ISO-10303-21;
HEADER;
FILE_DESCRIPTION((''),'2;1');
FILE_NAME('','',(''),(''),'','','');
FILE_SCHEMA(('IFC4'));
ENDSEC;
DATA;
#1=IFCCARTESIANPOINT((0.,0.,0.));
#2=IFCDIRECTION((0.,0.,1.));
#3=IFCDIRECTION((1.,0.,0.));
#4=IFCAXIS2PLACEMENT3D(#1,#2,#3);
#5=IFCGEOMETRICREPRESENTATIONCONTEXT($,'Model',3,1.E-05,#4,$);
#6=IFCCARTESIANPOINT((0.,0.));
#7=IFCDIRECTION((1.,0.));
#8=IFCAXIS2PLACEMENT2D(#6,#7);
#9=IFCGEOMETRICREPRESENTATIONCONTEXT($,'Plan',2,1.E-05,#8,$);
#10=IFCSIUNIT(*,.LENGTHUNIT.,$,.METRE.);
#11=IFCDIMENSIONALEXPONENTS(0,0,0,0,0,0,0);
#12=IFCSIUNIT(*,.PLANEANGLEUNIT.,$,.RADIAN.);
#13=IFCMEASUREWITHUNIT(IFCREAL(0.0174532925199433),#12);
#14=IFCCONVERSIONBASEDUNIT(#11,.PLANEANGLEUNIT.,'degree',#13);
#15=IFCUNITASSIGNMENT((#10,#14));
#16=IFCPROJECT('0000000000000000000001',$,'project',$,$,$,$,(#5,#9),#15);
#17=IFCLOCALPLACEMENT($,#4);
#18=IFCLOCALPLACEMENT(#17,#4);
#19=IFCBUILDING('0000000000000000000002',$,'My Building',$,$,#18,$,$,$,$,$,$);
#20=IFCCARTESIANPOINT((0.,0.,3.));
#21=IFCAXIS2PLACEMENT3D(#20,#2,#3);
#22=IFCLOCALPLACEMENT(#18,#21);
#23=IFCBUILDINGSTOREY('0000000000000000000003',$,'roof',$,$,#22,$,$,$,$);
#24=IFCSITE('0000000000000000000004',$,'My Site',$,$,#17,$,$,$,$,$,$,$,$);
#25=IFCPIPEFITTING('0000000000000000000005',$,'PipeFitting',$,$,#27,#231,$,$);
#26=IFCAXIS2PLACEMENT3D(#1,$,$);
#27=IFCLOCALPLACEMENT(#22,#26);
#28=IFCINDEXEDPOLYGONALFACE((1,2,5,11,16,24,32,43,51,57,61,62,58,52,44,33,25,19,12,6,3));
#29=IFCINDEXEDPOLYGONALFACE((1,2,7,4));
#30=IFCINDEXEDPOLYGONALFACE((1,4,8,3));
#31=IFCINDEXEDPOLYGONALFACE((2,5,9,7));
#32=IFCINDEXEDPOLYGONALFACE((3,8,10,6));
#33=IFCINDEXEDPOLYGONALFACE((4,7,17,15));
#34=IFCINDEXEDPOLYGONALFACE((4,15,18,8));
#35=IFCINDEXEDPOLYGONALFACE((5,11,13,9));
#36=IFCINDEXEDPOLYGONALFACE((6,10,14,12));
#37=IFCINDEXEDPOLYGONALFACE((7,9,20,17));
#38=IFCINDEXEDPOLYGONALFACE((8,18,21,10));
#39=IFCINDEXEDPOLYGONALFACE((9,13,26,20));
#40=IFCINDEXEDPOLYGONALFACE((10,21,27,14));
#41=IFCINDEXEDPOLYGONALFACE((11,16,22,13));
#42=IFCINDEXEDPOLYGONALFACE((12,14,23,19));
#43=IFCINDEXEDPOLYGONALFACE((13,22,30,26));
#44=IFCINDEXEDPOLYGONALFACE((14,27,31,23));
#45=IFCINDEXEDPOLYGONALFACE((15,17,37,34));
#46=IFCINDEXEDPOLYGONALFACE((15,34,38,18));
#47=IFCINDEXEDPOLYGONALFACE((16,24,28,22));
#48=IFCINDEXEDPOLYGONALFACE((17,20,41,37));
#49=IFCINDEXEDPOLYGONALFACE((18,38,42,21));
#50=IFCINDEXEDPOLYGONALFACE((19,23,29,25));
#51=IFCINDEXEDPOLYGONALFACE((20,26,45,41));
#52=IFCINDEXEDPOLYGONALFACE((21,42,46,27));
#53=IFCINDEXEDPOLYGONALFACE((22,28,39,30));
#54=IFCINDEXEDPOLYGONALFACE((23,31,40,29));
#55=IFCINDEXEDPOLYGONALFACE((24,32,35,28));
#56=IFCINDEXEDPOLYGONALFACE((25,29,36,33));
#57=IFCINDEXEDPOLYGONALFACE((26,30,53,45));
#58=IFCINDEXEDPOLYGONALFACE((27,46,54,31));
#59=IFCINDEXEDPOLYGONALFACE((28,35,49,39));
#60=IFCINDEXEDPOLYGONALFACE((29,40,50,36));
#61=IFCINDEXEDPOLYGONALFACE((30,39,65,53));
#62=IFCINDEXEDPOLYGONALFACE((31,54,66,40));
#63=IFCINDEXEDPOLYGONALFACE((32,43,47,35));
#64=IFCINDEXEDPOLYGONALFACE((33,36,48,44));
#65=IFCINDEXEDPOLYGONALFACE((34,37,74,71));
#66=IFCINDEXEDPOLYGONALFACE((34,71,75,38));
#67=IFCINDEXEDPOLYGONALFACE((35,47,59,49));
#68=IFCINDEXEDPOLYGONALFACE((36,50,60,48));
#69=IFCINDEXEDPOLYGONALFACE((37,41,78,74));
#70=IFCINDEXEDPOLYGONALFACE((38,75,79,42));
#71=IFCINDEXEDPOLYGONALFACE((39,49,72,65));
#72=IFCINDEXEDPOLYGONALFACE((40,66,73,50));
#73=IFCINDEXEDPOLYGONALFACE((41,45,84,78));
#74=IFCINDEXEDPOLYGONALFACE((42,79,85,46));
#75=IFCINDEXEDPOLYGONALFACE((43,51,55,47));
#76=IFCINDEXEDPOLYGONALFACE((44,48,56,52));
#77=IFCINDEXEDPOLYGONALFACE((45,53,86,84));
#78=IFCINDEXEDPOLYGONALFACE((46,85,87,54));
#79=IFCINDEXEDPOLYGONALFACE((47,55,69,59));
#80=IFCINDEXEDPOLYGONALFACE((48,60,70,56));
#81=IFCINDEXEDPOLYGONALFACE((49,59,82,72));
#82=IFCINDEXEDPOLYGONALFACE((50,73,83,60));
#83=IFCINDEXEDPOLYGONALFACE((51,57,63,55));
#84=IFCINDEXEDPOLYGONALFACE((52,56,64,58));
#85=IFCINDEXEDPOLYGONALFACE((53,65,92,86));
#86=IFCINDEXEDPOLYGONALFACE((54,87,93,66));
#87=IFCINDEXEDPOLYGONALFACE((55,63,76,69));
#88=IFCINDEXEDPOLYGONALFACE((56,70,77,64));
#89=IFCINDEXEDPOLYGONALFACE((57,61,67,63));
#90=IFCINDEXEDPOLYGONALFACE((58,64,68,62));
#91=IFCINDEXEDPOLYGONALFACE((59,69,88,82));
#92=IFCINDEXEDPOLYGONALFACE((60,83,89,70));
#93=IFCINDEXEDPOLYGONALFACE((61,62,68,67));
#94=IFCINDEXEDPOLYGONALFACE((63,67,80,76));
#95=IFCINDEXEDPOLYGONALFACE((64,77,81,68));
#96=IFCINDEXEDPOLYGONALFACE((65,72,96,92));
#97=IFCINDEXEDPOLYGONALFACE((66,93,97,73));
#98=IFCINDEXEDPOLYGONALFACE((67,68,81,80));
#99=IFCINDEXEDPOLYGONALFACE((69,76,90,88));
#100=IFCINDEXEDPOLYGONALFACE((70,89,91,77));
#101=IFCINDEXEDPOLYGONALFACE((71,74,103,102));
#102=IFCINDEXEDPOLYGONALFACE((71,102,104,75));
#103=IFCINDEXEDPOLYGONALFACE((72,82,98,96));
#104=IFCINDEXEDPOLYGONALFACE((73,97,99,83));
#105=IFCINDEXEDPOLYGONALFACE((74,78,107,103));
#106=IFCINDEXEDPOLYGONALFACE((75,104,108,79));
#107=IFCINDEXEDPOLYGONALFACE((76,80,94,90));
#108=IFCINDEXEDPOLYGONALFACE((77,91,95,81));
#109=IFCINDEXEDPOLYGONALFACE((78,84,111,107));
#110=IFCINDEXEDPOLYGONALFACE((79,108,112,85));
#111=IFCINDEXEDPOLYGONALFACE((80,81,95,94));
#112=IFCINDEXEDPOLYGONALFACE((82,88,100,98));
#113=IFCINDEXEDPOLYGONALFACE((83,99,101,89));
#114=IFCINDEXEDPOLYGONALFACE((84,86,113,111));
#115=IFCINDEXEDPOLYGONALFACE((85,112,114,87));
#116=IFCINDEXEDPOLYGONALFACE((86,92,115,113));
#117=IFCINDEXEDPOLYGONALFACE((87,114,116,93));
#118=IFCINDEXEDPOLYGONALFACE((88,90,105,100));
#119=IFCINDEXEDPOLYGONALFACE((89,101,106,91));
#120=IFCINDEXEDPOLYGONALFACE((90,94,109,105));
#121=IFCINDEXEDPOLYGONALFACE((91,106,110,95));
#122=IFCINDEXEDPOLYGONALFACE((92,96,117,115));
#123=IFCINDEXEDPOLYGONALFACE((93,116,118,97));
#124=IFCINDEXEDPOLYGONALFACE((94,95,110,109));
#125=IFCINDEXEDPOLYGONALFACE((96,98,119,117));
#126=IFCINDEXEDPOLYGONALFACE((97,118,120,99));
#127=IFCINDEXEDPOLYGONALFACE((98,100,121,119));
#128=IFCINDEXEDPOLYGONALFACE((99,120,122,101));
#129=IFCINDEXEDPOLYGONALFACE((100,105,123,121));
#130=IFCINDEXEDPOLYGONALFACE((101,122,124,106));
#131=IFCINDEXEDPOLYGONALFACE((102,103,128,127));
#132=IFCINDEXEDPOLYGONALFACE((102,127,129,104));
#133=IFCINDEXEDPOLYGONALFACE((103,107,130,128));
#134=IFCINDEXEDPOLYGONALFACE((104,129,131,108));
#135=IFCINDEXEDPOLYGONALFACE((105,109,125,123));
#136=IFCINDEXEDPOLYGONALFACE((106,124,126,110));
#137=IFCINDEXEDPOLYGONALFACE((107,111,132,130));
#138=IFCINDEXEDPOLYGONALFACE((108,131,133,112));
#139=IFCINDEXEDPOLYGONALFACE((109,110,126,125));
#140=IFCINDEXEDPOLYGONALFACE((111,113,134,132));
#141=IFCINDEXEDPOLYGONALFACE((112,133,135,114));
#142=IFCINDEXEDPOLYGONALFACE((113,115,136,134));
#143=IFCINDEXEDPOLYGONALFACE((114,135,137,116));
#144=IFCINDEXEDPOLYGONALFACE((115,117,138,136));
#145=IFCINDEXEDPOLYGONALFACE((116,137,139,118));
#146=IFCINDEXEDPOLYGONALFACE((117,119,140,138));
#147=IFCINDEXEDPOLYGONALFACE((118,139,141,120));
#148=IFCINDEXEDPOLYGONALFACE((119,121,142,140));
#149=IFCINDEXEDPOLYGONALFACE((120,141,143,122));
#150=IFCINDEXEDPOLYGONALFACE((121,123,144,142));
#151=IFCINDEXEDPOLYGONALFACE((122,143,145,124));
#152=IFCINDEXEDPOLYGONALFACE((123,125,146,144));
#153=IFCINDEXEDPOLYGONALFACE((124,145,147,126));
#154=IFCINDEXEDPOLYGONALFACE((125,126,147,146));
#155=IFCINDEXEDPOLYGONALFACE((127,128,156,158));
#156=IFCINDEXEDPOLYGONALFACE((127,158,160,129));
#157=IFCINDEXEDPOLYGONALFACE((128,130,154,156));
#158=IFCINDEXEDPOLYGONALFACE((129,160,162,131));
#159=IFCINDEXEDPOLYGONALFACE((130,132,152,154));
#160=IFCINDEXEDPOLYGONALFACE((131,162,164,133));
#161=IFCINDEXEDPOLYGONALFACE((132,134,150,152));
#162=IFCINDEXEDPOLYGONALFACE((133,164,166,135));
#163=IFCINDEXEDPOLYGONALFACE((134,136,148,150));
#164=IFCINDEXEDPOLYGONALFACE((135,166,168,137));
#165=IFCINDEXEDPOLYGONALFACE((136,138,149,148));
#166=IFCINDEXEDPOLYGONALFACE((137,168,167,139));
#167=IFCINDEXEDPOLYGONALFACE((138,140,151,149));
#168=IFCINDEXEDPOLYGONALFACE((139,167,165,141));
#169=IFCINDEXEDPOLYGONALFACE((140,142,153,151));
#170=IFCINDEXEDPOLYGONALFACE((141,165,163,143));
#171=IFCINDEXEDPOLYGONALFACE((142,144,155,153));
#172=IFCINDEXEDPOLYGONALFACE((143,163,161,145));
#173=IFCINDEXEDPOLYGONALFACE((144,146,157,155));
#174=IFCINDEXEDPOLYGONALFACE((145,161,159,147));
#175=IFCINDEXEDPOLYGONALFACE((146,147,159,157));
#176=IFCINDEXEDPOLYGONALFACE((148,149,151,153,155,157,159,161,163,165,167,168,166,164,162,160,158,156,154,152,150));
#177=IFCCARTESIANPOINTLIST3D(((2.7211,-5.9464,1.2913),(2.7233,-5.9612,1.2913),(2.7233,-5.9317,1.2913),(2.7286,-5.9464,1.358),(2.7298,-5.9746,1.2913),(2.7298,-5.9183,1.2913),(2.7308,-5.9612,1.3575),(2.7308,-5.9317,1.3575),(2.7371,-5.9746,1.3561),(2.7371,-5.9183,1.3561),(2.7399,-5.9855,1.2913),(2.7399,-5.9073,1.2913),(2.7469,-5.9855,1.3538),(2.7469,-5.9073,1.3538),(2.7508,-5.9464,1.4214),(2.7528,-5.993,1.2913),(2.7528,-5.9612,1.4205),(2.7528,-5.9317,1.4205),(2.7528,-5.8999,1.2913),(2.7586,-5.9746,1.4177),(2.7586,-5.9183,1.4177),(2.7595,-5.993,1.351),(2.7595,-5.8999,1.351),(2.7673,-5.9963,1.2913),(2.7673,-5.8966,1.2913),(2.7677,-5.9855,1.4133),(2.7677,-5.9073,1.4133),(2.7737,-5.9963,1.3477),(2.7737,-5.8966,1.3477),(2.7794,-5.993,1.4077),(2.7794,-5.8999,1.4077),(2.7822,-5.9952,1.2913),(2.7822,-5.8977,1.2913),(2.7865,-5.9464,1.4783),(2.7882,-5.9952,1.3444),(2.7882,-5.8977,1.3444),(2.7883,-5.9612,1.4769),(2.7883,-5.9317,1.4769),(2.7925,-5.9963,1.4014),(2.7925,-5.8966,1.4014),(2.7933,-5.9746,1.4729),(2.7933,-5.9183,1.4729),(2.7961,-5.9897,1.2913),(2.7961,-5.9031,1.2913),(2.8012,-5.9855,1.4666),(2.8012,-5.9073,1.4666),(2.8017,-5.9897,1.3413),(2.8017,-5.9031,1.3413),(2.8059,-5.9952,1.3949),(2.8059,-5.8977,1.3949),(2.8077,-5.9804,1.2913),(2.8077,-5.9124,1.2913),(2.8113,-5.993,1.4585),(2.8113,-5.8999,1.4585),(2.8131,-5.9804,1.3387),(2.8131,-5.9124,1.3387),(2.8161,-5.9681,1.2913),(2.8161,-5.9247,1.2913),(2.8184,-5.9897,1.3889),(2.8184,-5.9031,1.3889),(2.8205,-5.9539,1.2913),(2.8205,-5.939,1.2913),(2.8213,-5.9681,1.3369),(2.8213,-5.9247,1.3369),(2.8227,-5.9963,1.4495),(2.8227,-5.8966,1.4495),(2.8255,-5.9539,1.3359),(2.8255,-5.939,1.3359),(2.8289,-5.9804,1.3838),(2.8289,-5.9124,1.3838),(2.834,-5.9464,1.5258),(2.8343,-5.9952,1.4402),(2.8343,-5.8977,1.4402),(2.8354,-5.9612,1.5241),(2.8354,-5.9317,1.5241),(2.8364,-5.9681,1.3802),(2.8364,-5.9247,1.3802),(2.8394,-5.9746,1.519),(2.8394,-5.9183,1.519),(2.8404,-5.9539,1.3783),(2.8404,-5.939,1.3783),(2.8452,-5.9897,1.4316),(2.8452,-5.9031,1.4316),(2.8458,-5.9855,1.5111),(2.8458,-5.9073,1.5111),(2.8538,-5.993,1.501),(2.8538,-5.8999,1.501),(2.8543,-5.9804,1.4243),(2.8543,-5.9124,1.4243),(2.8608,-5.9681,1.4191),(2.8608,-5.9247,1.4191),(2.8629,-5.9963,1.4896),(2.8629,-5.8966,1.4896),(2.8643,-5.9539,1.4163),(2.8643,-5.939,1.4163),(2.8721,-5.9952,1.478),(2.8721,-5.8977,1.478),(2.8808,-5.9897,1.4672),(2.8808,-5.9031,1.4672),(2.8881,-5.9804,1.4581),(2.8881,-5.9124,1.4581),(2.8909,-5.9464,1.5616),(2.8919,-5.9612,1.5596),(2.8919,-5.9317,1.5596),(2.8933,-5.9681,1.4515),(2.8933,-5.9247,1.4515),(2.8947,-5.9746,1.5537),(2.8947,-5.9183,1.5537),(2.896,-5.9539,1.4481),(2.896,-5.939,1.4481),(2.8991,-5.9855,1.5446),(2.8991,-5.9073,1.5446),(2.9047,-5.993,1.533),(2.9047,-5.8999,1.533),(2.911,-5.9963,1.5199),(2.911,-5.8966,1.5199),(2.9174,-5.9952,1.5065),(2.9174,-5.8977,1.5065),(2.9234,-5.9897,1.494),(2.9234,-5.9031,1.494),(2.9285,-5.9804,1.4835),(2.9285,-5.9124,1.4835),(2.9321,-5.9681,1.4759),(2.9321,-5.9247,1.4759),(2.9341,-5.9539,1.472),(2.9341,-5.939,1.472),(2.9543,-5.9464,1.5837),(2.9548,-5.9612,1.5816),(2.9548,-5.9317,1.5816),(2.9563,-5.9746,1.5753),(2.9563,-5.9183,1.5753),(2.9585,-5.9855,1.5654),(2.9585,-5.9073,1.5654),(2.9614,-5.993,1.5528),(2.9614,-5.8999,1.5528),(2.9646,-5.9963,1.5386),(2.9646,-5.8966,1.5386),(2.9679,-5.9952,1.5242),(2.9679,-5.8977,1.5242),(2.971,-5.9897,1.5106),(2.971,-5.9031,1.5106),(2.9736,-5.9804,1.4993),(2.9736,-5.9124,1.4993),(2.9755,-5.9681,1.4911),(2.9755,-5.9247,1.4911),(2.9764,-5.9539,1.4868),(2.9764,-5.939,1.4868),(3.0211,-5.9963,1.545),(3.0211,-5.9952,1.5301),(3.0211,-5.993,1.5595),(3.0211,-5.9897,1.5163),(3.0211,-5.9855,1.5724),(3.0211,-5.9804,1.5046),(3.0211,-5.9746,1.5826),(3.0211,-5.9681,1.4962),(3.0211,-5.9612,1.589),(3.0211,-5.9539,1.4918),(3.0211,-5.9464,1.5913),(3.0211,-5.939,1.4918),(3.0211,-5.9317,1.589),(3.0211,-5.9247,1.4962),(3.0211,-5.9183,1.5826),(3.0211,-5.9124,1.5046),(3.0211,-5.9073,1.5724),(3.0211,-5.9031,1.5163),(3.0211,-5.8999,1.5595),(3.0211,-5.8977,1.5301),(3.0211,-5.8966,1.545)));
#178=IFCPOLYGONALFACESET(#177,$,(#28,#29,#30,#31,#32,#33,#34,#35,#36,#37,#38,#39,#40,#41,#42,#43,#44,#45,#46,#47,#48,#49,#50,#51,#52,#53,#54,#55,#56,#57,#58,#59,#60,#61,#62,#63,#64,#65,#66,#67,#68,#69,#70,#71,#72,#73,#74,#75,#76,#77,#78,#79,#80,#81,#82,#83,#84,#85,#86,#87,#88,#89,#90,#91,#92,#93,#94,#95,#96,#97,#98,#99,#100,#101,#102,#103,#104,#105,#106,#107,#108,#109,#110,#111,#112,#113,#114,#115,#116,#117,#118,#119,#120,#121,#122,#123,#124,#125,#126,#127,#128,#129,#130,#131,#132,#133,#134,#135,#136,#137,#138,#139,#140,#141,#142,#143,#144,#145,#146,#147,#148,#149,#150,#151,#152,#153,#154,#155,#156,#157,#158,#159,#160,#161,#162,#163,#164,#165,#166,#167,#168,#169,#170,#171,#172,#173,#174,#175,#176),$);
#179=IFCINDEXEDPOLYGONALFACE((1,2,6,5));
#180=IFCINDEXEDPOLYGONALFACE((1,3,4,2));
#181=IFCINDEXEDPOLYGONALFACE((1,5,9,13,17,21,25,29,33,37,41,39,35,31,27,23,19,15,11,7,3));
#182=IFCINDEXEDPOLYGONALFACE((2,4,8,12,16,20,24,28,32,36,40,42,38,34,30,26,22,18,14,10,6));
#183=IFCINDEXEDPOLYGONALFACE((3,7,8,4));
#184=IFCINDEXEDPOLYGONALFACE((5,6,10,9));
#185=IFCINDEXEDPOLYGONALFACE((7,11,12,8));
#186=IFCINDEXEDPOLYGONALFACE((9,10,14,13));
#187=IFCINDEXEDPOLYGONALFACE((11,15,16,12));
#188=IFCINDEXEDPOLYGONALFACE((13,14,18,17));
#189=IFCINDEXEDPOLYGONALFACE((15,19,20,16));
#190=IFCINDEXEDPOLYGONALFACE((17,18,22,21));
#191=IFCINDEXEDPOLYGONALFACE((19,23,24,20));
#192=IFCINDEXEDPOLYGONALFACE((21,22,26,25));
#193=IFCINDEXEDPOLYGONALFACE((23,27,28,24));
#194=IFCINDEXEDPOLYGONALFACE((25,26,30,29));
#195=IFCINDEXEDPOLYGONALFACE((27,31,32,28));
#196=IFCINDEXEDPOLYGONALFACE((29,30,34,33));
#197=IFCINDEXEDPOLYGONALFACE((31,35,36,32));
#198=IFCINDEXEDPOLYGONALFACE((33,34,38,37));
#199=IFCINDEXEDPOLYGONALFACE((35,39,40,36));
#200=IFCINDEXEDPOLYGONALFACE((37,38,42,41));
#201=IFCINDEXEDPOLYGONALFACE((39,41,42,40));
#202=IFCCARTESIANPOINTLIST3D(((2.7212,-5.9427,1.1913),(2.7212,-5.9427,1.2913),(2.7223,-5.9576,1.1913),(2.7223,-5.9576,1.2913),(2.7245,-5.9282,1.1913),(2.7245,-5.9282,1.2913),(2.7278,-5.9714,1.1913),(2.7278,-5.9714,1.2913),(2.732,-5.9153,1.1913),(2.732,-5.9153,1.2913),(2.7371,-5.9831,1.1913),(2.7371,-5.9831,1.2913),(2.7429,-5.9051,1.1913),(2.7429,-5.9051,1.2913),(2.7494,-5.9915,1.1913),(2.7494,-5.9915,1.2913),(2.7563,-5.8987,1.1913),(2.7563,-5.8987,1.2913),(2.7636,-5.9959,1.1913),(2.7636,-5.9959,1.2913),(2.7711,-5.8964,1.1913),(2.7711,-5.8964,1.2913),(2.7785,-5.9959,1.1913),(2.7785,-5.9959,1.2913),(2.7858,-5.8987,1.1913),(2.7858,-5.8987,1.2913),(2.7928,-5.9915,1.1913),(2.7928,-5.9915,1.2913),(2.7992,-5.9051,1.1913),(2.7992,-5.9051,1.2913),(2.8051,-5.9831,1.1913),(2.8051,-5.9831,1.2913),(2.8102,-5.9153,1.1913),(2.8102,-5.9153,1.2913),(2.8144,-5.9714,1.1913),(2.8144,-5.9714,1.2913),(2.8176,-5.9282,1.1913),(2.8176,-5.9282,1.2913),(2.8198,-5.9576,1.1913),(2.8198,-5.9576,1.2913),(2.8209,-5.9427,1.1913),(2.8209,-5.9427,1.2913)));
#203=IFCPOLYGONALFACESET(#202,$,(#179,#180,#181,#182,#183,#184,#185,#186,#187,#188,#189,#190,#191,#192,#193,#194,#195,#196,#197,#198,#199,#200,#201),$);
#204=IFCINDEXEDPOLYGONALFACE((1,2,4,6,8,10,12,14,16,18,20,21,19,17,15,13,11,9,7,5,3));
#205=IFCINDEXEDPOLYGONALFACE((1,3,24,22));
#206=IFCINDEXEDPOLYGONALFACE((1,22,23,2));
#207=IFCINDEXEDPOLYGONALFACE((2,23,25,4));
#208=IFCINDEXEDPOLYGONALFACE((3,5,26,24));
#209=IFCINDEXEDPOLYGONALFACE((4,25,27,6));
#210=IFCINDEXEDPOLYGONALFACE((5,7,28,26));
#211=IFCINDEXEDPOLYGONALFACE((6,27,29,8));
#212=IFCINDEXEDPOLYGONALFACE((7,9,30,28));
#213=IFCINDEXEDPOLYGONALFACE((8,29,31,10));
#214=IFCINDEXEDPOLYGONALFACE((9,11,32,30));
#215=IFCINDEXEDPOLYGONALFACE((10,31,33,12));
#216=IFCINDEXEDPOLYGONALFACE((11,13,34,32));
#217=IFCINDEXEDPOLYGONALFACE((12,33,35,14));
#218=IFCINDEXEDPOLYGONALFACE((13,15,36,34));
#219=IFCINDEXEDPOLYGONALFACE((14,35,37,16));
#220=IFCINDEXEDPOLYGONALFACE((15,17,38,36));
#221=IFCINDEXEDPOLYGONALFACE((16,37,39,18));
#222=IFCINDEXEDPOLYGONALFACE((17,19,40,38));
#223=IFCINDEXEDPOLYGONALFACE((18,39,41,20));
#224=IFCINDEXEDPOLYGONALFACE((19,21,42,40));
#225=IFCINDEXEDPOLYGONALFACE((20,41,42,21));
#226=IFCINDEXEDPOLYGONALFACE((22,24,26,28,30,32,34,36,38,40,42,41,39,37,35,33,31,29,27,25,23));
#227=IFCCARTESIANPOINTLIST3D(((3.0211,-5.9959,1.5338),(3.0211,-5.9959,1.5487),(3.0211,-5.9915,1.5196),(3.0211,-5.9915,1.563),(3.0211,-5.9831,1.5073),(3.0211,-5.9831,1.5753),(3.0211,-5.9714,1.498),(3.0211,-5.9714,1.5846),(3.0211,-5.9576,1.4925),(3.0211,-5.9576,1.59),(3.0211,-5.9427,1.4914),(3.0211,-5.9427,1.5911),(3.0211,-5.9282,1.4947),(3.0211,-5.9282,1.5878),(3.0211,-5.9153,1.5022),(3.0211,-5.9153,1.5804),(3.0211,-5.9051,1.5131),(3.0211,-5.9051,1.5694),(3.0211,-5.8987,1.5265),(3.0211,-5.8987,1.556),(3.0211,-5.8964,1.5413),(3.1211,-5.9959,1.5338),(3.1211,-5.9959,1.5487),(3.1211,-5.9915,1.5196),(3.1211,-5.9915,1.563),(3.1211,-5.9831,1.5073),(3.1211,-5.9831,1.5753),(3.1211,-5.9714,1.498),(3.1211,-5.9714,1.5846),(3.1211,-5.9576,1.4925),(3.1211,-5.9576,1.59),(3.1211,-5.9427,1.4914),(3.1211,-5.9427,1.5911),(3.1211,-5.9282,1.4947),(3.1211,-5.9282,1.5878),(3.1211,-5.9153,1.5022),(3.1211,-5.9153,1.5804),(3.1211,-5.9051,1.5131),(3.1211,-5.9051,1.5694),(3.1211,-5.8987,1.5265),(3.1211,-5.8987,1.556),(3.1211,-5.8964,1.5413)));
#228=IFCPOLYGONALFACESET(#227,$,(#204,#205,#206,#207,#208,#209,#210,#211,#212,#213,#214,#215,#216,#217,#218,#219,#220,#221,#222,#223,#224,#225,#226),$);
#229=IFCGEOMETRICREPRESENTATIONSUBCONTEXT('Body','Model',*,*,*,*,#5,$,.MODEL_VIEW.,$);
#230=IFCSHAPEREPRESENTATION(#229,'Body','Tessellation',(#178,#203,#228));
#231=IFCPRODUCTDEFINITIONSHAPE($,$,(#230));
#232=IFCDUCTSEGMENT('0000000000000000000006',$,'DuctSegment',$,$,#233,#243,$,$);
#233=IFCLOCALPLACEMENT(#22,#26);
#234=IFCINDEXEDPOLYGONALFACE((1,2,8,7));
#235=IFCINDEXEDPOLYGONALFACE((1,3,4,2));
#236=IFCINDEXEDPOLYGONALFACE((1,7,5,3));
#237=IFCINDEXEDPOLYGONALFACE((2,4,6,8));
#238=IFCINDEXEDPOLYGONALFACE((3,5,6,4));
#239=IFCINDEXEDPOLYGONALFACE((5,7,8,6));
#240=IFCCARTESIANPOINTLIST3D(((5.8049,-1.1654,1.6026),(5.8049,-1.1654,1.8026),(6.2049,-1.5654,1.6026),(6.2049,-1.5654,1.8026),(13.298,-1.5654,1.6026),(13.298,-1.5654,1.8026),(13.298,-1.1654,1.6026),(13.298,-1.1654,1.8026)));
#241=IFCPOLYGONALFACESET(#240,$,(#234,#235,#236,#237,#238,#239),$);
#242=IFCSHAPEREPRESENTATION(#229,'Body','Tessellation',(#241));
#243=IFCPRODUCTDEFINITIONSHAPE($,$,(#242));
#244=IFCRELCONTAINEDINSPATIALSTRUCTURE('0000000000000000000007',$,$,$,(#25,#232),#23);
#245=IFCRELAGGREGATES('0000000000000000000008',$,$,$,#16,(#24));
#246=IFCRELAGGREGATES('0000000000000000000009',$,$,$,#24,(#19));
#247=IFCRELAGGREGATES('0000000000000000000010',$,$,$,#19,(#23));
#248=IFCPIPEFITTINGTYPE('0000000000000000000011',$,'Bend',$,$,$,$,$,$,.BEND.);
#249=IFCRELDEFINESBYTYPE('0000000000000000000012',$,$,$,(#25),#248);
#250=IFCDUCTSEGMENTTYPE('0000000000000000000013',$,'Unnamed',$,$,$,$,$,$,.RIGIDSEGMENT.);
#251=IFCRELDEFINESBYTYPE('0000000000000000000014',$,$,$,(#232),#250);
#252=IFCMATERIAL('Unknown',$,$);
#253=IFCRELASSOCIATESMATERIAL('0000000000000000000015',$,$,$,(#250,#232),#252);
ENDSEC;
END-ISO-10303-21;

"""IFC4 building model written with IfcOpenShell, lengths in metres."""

from ifc_helpers import new_model, entity, si_unit, converted_unit, frame, origin_with_axes, origin_2d_with_axis, place, context, subcontext, project, spatial, rectangle, circle, extrude, clip, halfspace, source, transform, mapped, material, material_profile, profile_set, profile_usage, type_object, type_shapes, element, save


model = new_model("IFC4")

# Units and contexts
model_context = context("Model", 3, precision=1e-05, world=origin_with_axes())
plan_context = context("Plan", 2, precision=1e-05, world=origin_2d_with_axis())
body_context = subcontext(model_context, "Body", "Model", "MODEL_VIEW")
ifc_project = project(units=[si_unit("LENGTHUNIT", "METRE"), converted_unit("PLANEANGLEUNIT", "degree", entity("IfcReal", 0.0174532925199433), si_unit("PLANEANGLEUNIT", "RADIAN"), dimensions=[0, 0, 0, 0, 0, 0, 0])], contexts=[model_context, plan_context])

# Site, building, storey
site_placement = place(None, origin_with_axes())
site = spatial("IfcSite", under=ifc_project, at=site_placement, Name="My Site")
building_placement = place(site_placement, origin_with_axes())
building = spatial("IfcBuilding", under=site, at=building_placement, Name="My Building")
storey_placement = place(building_placement, frame((0.0, 0.0, 3.0), z_axis=(0.0, 0.0, 1.0), x_axis=(1.0, 0.0, 0.0)))
storey = spatial("IfcBuildingStorey", under=building, at=storey_placement, Name="roof")

# Shared definitions
ifc_material = material(Name="Unknown")

# Pipe fitting
pipe_fitting_type_1 = type_object("IfcPipeFittingType", Name="Bend", PredefinedType="BEND")
shared_shape = source(origin_with_axes(), body_context, "Body", "SolidModel", [
    entity("IfcSweptDiskSolid", entity("IfcIndexedPolyCurve", entity("IfcCartesianPointList3D", [[0.0, 0.0, 0.1], [0.0, -0.0732, 0.2768], [0.0, -0.25, 0.35]]), [entity("IfcArcIndex", [1, 2, 3])]), 0.05),
    extrude(circle(Radius=0.05), origin_with_axes(), (0.0, 0.0, 1.0), 0.1),
    extrude(circle(Radius=0.05), frame((0.0, -0.25, 0.35), z_axis=(0.0, -1.0, 0.0), x_axis=(1.0, 0.0, 0.0)), (0.0, 0.0, 1.0), 0.1),
])
type_shapes(pipe_fitting_type_1, [shared_shape])
for number, where, z_axis, x_axis, name in (
    (1, (2.7711, -5.9464, 1.1913), (-0.000001, 0.000001, 1.0), (0.0, 1.0, -0.000001), "PipeFitting"),
):
    element("IfcPipeFitting", number, at=place(storey_placement, frame(where, z_axis=z_axis, x_axis=x_axis)), inside=storey, type_object=pipe_fitting_type_1, Name=name, context=body_context, shape_type="MappedRepresentation", body=[
        mapped(shared_shape, transform((0.0, 0.0, 0.0), x_axis=(1.0, 0.0, 0.0), y_axis=(0.0, 1.0, 0.0), z_axis=(0.0, 0.0, 1.0), scale=1.0)),
    ])

# Duct segment
ifc_material_profile_1 = material_profile(ifc_material, rectangle(XDim=0.4, YDim=0.2))
ifc_profile_set_1 = profile_set([ifc_material_profile_1])
ifc_profile_usage_1 = profile_usage(ifc_profile_set_1, cardinal=5)
duct_segment_type = type_object("IfcDuctSegmentType", Name="Unnamed", PredefinedType="RIGIDSEGMENT", material=ifc_profile_set_1)
duct_segment_1_placement = place(storey_placement, frame((13.298, -1.3654, 1.7026), z_axis=(-1.0, 0.0, 0.0), x_axis=(0.0, -1.0, 0.0)))
element("IfcDuctSegment", 2, at=duct_segment_1_placement, inside=storey, type_object=duct_segment_type, material=ifc_profile_usage_1, Name="DuctSegment", context=body_context, shape_type="Clipping", body=[
    clip(extrude(rectangle(XDim=0.4, YDim=0.2), origin_with_axes(), (0.0, 0.0, 1.0), 7.493), halfspace(frame((-0.2, -1.5, 7.493), z_axis=(0.707107, 0.0, 0.707107), x_axis=(0.0, -1.0, 0.0)), False)),
])

save(model, "model.ifc")
